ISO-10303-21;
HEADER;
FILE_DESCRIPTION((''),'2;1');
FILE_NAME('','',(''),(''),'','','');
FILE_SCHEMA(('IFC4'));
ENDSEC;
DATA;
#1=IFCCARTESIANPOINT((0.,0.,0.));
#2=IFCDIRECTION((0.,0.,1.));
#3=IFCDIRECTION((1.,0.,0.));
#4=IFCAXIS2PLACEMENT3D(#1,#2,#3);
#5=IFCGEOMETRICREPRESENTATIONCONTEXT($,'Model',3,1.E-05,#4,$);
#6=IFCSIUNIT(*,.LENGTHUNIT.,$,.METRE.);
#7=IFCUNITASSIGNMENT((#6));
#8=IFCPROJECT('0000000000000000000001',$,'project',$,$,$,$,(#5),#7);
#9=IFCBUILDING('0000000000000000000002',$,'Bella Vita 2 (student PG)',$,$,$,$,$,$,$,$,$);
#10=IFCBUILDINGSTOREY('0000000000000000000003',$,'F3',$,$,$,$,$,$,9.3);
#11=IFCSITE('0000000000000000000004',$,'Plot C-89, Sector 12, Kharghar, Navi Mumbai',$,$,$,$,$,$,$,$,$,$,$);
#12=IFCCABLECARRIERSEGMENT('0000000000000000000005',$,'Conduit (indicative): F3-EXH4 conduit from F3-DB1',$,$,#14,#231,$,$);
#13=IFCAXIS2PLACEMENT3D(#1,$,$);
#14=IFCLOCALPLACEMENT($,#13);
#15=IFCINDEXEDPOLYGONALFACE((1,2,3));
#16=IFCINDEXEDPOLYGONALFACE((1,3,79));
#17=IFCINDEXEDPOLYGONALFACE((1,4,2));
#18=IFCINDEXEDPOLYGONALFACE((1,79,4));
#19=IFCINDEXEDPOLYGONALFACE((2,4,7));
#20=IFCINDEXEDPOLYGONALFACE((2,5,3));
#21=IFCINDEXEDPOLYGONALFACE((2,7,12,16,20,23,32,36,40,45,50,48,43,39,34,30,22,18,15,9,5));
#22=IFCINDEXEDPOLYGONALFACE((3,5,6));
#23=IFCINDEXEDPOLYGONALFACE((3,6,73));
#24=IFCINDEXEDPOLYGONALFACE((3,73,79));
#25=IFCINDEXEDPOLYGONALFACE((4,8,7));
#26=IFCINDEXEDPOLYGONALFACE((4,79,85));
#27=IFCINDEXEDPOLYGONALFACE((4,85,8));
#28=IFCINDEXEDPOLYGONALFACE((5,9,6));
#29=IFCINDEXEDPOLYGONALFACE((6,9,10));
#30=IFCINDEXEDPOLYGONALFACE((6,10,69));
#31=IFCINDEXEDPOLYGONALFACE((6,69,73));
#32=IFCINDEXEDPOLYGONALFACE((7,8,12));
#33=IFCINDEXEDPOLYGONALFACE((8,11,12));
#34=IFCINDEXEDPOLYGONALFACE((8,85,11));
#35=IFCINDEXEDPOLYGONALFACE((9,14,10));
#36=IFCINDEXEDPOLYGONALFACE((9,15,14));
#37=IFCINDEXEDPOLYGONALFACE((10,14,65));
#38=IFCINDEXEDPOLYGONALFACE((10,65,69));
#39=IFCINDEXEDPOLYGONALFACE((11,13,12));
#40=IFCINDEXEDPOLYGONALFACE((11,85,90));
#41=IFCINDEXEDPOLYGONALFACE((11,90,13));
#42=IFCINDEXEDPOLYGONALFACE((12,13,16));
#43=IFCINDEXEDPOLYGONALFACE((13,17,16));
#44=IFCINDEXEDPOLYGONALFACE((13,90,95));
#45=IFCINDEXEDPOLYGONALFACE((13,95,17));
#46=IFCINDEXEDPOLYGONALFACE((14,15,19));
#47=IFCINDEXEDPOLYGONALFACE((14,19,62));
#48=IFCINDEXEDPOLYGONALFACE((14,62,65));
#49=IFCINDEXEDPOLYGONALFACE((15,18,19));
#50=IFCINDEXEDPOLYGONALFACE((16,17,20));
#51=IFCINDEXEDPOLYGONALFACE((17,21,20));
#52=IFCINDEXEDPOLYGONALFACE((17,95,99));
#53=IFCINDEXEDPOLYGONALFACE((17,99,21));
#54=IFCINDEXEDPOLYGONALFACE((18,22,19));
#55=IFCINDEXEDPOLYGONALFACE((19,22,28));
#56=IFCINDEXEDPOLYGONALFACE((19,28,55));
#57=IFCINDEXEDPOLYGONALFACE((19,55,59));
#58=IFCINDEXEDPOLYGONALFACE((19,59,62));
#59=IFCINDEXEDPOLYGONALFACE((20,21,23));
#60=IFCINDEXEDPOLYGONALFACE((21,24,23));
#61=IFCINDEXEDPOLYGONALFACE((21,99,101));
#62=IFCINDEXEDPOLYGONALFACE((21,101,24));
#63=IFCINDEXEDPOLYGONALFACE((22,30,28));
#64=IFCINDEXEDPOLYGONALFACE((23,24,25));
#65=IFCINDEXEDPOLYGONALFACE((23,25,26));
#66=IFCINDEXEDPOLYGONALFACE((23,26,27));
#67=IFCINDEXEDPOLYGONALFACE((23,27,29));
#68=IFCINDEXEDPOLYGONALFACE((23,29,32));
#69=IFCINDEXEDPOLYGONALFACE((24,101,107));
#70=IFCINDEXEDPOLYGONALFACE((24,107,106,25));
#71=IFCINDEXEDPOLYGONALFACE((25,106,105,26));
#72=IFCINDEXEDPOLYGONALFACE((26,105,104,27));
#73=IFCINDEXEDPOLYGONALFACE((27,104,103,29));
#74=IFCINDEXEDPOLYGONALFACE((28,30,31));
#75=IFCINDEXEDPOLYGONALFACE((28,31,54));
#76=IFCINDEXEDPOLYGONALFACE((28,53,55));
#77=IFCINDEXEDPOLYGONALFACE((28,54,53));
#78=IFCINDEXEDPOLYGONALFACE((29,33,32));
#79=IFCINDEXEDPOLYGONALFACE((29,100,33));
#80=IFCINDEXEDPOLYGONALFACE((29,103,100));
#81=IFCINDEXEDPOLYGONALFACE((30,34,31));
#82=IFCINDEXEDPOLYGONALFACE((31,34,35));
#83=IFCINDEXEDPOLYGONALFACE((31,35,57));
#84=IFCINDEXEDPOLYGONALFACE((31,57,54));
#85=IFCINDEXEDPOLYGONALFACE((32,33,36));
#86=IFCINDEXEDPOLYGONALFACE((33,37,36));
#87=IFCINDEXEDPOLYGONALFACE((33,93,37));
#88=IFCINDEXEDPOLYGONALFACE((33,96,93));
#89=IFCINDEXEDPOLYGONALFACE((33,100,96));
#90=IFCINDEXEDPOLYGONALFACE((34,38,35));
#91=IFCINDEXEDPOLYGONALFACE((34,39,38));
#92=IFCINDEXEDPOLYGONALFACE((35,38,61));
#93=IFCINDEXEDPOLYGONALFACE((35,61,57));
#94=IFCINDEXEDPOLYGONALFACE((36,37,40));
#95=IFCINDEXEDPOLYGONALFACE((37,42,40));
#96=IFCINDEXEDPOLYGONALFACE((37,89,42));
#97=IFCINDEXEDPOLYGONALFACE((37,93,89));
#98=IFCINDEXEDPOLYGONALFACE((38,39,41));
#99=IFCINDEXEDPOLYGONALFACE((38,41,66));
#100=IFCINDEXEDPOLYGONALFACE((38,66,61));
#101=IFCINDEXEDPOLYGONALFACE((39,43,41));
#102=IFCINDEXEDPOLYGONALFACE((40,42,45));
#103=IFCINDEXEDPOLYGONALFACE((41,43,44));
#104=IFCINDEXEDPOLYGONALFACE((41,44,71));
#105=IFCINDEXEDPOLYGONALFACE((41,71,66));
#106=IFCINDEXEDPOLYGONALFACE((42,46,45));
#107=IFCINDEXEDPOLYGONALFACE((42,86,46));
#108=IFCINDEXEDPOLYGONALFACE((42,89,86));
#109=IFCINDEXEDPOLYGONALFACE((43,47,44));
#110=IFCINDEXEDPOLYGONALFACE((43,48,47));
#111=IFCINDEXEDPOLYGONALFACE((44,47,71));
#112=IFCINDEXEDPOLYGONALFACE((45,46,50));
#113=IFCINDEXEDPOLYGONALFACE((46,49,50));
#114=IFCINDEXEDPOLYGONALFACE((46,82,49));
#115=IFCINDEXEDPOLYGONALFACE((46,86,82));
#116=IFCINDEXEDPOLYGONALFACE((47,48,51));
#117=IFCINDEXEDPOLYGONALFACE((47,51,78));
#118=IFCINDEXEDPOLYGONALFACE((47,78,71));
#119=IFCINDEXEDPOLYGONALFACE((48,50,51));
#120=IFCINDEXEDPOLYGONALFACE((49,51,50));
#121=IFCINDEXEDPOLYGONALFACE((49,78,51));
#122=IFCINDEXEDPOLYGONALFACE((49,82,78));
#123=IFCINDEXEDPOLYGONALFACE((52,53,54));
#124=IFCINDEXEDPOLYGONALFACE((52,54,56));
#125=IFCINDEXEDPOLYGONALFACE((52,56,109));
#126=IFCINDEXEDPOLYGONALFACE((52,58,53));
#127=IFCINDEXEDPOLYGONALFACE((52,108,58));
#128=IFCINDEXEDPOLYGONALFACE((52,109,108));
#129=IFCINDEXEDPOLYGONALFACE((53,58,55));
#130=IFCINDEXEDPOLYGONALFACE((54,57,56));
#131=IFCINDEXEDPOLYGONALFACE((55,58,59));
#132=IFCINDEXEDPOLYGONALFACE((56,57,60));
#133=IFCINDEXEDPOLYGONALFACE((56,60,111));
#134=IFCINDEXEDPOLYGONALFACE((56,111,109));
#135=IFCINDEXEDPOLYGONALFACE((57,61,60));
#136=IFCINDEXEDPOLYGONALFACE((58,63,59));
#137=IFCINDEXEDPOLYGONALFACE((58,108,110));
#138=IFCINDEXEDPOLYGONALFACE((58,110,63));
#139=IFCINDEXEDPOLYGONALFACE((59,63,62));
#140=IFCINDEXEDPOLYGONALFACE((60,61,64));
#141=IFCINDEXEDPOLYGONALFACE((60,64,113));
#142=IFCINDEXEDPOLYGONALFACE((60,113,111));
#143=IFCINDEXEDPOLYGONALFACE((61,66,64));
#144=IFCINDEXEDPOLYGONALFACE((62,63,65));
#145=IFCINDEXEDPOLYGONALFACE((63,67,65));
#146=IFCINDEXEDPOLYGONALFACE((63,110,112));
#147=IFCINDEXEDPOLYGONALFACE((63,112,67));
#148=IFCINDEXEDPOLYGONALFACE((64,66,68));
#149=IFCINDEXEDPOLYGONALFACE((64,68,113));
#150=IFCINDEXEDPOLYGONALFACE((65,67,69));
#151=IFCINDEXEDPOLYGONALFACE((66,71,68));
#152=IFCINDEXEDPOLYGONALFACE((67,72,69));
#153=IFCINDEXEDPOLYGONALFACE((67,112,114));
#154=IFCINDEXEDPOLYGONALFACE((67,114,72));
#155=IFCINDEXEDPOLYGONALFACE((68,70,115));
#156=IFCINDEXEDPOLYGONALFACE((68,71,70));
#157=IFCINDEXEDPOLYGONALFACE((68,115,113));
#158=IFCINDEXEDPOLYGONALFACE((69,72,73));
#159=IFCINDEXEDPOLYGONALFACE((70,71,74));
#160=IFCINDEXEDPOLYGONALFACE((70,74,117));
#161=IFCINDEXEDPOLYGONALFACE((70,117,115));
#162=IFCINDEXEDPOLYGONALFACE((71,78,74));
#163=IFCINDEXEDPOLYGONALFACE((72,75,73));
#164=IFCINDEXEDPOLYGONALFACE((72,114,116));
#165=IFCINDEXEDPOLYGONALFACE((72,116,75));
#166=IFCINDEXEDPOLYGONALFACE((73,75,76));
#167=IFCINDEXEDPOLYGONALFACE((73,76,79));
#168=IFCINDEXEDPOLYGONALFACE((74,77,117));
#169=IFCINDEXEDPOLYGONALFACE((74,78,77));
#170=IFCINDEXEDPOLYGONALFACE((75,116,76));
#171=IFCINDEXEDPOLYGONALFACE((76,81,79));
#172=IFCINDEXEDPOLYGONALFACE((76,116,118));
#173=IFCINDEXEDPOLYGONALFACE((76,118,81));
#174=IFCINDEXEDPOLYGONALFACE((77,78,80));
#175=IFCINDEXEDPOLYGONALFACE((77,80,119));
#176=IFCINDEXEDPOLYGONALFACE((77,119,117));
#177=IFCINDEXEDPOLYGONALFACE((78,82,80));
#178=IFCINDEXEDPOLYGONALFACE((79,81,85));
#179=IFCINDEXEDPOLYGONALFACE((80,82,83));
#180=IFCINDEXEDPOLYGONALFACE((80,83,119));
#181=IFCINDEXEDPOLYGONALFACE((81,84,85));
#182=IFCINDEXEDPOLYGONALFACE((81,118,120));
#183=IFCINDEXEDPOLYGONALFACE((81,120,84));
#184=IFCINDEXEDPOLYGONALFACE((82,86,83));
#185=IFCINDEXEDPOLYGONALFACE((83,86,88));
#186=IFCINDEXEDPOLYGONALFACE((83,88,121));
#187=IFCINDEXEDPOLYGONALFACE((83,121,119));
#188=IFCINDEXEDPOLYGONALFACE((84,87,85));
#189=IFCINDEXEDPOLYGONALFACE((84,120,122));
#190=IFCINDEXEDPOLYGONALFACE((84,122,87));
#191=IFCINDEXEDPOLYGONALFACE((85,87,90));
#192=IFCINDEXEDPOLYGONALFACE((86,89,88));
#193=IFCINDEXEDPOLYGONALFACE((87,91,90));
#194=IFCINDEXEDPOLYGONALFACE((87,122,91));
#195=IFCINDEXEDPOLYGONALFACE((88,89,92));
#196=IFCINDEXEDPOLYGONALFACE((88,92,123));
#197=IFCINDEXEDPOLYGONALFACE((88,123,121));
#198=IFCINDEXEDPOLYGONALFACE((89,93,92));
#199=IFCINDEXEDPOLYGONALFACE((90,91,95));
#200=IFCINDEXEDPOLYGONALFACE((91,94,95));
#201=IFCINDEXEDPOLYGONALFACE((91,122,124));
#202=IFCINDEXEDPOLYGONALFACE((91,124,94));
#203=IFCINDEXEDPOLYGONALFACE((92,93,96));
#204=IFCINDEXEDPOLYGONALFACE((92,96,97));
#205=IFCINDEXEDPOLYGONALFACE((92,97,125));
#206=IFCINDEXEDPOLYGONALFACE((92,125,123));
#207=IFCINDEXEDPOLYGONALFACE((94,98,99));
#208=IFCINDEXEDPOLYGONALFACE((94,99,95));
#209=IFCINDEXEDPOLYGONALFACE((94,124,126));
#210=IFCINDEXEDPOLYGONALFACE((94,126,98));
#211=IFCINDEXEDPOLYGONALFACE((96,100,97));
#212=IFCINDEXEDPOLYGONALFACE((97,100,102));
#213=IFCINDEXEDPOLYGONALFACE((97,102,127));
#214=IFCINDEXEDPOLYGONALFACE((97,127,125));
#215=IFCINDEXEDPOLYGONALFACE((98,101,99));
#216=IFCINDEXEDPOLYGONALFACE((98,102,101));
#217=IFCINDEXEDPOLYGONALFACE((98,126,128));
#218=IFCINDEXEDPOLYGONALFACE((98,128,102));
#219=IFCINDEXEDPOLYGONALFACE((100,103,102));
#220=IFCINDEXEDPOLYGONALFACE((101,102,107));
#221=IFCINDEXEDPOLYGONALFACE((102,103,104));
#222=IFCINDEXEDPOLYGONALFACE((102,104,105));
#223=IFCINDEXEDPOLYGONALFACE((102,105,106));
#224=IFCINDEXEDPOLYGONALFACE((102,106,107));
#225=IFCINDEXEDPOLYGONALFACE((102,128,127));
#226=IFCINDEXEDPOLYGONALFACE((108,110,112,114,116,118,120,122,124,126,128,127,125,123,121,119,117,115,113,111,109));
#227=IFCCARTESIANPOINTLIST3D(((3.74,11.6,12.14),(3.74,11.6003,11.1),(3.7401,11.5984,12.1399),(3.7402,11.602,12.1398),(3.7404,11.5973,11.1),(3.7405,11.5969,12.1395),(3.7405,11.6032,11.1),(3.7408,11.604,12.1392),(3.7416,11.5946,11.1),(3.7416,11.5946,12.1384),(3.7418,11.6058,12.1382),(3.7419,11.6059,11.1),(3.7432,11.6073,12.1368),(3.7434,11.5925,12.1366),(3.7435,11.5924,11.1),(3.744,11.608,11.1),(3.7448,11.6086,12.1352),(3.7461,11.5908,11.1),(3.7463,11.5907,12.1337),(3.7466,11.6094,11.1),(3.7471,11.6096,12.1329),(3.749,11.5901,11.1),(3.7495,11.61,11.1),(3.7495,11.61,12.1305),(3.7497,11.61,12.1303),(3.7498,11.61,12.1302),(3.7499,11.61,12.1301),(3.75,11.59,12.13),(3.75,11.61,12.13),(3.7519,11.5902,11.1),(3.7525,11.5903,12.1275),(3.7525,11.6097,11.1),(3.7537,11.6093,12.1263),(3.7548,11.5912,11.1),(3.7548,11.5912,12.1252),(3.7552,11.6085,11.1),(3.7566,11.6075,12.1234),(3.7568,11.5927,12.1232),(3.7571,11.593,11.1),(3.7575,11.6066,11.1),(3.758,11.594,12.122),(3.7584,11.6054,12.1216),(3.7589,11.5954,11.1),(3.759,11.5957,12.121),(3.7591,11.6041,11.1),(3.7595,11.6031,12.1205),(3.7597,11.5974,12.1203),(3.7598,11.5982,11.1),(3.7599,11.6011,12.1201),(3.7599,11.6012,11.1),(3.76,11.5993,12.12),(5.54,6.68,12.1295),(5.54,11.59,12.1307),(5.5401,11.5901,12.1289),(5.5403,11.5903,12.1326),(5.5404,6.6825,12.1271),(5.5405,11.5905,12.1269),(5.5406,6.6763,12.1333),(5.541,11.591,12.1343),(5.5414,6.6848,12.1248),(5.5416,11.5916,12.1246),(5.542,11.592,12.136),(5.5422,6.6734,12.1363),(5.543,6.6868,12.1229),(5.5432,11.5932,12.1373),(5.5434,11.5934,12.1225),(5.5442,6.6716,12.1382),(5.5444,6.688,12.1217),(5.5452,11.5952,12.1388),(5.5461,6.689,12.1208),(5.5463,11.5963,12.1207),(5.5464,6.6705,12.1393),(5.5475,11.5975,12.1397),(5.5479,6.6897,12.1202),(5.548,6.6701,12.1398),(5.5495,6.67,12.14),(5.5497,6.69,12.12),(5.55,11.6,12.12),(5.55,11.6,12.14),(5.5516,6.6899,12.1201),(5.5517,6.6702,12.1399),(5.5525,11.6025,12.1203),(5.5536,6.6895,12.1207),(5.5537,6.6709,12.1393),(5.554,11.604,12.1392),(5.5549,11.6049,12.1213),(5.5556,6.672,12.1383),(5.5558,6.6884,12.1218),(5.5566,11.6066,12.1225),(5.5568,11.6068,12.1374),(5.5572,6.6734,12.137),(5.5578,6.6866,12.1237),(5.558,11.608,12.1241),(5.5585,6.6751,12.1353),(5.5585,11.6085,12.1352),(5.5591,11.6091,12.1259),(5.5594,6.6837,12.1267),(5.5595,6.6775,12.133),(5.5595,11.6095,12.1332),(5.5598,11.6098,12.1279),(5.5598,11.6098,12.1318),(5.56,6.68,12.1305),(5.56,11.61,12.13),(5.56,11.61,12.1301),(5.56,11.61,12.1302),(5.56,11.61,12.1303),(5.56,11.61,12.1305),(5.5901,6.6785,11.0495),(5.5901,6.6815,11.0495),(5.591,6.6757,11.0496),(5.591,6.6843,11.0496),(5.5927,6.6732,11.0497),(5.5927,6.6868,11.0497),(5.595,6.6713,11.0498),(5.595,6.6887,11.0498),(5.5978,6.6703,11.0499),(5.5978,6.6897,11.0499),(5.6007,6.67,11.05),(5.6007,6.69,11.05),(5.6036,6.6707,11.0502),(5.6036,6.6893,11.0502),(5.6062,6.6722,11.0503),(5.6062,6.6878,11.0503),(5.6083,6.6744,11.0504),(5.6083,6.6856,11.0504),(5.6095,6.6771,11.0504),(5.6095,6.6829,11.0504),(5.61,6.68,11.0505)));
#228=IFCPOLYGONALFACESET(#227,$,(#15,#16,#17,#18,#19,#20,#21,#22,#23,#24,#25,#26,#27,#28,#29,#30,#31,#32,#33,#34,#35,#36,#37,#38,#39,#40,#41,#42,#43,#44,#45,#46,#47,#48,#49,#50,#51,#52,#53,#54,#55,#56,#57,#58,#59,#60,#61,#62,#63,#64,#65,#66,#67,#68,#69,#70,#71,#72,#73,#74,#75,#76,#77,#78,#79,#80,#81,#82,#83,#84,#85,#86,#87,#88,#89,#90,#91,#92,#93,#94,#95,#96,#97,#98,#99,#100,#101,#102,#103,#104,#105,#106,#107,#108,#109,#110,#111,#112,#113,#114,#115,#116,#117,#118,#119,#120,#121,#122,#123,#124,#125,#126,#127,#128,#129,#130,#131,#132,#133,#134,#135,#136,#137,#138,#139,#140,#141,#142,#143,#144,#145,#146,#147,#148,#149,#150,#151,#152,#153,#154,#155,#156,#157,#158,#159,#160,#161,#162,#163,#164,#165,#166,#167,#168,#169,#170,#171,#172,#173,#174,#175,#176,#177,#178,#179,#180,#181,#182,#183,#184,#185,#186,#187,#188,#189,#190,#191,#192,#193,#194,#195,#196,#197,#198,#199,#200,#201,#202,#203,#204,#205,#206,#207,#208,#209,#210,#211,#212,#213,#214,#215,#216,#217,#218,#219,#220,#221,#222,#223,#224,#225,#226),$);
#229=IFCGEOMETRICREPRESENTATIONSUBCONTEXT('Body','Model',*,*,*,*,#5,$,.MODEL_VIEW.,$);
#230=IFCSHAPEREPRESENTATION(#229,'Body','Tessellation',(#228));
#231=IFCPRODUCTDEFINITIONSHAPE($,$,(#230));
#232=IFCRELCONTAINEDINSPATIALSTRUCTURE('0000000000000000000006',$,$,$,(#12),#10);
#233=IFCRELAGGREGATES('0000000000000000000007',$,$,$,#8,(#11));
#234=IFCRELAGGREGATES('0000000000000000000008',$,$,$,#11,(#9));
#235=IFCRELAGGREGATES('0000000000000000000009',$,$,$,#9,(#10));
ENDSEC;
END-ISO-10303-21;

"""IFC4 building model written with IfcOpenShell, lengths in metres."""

from ifc_helpers import new_model, entity, si_unit, origin, origin_with_axes, place, context, subcontext, project, spatial, element, save


model = new_model("IFC4")

# Units and contexts
model_context = context("Model", 3, precision=1e-05, world=origin_with_axes())
body_context = subcontext(model_context, "Body", "Model", "MODEL_VIEW")
ifc_project = project(units=[si_unit("LENGTHUNIT", "METRE")], contexts=[model_context])

# Site, building, storey
site = spatial("IfcSite", under=ifc_project, Name="Plot C-89, Sector 12, Kharghar, Navi Mumbai")
building = spatial("IfcBuilding", under=site, Name="Bella Vita 2 (student PG)")
storey = spatial("IfcBuildingStorey", under=building, Name="F3", Elevation=9.3)

# Cable carrier segment
cable_carrier_segment_1_placement = place(None, origin())
element("IfcCableCarrierSegment", 1, at=cable_carrier_segment_1_placement, inside=storey, Name="Conduit (indicative): F3-EXH4 conduit from F3-DB1", context=body_context, shape_type="AdvancedSweptSolid", body=[
    entity("IfcSweptDiskSolid", entity("IfcPolyline", [entity("IfcCartesianPoint", [5.6, 6.68, 11.05]), entity("IfcCartesianPoint", [5.55, 6.68, 12.13]), entity("IfcCartesianPoint", [5.55, 11.6, 12.13]), entity("IfcCartesianPoint", [3.75, 11.6, 12.13]), entity("IfcCartesianPoint", [3.75, 11.6, 11.1])]), 0.01),
])

save(model, "model.ifc")
